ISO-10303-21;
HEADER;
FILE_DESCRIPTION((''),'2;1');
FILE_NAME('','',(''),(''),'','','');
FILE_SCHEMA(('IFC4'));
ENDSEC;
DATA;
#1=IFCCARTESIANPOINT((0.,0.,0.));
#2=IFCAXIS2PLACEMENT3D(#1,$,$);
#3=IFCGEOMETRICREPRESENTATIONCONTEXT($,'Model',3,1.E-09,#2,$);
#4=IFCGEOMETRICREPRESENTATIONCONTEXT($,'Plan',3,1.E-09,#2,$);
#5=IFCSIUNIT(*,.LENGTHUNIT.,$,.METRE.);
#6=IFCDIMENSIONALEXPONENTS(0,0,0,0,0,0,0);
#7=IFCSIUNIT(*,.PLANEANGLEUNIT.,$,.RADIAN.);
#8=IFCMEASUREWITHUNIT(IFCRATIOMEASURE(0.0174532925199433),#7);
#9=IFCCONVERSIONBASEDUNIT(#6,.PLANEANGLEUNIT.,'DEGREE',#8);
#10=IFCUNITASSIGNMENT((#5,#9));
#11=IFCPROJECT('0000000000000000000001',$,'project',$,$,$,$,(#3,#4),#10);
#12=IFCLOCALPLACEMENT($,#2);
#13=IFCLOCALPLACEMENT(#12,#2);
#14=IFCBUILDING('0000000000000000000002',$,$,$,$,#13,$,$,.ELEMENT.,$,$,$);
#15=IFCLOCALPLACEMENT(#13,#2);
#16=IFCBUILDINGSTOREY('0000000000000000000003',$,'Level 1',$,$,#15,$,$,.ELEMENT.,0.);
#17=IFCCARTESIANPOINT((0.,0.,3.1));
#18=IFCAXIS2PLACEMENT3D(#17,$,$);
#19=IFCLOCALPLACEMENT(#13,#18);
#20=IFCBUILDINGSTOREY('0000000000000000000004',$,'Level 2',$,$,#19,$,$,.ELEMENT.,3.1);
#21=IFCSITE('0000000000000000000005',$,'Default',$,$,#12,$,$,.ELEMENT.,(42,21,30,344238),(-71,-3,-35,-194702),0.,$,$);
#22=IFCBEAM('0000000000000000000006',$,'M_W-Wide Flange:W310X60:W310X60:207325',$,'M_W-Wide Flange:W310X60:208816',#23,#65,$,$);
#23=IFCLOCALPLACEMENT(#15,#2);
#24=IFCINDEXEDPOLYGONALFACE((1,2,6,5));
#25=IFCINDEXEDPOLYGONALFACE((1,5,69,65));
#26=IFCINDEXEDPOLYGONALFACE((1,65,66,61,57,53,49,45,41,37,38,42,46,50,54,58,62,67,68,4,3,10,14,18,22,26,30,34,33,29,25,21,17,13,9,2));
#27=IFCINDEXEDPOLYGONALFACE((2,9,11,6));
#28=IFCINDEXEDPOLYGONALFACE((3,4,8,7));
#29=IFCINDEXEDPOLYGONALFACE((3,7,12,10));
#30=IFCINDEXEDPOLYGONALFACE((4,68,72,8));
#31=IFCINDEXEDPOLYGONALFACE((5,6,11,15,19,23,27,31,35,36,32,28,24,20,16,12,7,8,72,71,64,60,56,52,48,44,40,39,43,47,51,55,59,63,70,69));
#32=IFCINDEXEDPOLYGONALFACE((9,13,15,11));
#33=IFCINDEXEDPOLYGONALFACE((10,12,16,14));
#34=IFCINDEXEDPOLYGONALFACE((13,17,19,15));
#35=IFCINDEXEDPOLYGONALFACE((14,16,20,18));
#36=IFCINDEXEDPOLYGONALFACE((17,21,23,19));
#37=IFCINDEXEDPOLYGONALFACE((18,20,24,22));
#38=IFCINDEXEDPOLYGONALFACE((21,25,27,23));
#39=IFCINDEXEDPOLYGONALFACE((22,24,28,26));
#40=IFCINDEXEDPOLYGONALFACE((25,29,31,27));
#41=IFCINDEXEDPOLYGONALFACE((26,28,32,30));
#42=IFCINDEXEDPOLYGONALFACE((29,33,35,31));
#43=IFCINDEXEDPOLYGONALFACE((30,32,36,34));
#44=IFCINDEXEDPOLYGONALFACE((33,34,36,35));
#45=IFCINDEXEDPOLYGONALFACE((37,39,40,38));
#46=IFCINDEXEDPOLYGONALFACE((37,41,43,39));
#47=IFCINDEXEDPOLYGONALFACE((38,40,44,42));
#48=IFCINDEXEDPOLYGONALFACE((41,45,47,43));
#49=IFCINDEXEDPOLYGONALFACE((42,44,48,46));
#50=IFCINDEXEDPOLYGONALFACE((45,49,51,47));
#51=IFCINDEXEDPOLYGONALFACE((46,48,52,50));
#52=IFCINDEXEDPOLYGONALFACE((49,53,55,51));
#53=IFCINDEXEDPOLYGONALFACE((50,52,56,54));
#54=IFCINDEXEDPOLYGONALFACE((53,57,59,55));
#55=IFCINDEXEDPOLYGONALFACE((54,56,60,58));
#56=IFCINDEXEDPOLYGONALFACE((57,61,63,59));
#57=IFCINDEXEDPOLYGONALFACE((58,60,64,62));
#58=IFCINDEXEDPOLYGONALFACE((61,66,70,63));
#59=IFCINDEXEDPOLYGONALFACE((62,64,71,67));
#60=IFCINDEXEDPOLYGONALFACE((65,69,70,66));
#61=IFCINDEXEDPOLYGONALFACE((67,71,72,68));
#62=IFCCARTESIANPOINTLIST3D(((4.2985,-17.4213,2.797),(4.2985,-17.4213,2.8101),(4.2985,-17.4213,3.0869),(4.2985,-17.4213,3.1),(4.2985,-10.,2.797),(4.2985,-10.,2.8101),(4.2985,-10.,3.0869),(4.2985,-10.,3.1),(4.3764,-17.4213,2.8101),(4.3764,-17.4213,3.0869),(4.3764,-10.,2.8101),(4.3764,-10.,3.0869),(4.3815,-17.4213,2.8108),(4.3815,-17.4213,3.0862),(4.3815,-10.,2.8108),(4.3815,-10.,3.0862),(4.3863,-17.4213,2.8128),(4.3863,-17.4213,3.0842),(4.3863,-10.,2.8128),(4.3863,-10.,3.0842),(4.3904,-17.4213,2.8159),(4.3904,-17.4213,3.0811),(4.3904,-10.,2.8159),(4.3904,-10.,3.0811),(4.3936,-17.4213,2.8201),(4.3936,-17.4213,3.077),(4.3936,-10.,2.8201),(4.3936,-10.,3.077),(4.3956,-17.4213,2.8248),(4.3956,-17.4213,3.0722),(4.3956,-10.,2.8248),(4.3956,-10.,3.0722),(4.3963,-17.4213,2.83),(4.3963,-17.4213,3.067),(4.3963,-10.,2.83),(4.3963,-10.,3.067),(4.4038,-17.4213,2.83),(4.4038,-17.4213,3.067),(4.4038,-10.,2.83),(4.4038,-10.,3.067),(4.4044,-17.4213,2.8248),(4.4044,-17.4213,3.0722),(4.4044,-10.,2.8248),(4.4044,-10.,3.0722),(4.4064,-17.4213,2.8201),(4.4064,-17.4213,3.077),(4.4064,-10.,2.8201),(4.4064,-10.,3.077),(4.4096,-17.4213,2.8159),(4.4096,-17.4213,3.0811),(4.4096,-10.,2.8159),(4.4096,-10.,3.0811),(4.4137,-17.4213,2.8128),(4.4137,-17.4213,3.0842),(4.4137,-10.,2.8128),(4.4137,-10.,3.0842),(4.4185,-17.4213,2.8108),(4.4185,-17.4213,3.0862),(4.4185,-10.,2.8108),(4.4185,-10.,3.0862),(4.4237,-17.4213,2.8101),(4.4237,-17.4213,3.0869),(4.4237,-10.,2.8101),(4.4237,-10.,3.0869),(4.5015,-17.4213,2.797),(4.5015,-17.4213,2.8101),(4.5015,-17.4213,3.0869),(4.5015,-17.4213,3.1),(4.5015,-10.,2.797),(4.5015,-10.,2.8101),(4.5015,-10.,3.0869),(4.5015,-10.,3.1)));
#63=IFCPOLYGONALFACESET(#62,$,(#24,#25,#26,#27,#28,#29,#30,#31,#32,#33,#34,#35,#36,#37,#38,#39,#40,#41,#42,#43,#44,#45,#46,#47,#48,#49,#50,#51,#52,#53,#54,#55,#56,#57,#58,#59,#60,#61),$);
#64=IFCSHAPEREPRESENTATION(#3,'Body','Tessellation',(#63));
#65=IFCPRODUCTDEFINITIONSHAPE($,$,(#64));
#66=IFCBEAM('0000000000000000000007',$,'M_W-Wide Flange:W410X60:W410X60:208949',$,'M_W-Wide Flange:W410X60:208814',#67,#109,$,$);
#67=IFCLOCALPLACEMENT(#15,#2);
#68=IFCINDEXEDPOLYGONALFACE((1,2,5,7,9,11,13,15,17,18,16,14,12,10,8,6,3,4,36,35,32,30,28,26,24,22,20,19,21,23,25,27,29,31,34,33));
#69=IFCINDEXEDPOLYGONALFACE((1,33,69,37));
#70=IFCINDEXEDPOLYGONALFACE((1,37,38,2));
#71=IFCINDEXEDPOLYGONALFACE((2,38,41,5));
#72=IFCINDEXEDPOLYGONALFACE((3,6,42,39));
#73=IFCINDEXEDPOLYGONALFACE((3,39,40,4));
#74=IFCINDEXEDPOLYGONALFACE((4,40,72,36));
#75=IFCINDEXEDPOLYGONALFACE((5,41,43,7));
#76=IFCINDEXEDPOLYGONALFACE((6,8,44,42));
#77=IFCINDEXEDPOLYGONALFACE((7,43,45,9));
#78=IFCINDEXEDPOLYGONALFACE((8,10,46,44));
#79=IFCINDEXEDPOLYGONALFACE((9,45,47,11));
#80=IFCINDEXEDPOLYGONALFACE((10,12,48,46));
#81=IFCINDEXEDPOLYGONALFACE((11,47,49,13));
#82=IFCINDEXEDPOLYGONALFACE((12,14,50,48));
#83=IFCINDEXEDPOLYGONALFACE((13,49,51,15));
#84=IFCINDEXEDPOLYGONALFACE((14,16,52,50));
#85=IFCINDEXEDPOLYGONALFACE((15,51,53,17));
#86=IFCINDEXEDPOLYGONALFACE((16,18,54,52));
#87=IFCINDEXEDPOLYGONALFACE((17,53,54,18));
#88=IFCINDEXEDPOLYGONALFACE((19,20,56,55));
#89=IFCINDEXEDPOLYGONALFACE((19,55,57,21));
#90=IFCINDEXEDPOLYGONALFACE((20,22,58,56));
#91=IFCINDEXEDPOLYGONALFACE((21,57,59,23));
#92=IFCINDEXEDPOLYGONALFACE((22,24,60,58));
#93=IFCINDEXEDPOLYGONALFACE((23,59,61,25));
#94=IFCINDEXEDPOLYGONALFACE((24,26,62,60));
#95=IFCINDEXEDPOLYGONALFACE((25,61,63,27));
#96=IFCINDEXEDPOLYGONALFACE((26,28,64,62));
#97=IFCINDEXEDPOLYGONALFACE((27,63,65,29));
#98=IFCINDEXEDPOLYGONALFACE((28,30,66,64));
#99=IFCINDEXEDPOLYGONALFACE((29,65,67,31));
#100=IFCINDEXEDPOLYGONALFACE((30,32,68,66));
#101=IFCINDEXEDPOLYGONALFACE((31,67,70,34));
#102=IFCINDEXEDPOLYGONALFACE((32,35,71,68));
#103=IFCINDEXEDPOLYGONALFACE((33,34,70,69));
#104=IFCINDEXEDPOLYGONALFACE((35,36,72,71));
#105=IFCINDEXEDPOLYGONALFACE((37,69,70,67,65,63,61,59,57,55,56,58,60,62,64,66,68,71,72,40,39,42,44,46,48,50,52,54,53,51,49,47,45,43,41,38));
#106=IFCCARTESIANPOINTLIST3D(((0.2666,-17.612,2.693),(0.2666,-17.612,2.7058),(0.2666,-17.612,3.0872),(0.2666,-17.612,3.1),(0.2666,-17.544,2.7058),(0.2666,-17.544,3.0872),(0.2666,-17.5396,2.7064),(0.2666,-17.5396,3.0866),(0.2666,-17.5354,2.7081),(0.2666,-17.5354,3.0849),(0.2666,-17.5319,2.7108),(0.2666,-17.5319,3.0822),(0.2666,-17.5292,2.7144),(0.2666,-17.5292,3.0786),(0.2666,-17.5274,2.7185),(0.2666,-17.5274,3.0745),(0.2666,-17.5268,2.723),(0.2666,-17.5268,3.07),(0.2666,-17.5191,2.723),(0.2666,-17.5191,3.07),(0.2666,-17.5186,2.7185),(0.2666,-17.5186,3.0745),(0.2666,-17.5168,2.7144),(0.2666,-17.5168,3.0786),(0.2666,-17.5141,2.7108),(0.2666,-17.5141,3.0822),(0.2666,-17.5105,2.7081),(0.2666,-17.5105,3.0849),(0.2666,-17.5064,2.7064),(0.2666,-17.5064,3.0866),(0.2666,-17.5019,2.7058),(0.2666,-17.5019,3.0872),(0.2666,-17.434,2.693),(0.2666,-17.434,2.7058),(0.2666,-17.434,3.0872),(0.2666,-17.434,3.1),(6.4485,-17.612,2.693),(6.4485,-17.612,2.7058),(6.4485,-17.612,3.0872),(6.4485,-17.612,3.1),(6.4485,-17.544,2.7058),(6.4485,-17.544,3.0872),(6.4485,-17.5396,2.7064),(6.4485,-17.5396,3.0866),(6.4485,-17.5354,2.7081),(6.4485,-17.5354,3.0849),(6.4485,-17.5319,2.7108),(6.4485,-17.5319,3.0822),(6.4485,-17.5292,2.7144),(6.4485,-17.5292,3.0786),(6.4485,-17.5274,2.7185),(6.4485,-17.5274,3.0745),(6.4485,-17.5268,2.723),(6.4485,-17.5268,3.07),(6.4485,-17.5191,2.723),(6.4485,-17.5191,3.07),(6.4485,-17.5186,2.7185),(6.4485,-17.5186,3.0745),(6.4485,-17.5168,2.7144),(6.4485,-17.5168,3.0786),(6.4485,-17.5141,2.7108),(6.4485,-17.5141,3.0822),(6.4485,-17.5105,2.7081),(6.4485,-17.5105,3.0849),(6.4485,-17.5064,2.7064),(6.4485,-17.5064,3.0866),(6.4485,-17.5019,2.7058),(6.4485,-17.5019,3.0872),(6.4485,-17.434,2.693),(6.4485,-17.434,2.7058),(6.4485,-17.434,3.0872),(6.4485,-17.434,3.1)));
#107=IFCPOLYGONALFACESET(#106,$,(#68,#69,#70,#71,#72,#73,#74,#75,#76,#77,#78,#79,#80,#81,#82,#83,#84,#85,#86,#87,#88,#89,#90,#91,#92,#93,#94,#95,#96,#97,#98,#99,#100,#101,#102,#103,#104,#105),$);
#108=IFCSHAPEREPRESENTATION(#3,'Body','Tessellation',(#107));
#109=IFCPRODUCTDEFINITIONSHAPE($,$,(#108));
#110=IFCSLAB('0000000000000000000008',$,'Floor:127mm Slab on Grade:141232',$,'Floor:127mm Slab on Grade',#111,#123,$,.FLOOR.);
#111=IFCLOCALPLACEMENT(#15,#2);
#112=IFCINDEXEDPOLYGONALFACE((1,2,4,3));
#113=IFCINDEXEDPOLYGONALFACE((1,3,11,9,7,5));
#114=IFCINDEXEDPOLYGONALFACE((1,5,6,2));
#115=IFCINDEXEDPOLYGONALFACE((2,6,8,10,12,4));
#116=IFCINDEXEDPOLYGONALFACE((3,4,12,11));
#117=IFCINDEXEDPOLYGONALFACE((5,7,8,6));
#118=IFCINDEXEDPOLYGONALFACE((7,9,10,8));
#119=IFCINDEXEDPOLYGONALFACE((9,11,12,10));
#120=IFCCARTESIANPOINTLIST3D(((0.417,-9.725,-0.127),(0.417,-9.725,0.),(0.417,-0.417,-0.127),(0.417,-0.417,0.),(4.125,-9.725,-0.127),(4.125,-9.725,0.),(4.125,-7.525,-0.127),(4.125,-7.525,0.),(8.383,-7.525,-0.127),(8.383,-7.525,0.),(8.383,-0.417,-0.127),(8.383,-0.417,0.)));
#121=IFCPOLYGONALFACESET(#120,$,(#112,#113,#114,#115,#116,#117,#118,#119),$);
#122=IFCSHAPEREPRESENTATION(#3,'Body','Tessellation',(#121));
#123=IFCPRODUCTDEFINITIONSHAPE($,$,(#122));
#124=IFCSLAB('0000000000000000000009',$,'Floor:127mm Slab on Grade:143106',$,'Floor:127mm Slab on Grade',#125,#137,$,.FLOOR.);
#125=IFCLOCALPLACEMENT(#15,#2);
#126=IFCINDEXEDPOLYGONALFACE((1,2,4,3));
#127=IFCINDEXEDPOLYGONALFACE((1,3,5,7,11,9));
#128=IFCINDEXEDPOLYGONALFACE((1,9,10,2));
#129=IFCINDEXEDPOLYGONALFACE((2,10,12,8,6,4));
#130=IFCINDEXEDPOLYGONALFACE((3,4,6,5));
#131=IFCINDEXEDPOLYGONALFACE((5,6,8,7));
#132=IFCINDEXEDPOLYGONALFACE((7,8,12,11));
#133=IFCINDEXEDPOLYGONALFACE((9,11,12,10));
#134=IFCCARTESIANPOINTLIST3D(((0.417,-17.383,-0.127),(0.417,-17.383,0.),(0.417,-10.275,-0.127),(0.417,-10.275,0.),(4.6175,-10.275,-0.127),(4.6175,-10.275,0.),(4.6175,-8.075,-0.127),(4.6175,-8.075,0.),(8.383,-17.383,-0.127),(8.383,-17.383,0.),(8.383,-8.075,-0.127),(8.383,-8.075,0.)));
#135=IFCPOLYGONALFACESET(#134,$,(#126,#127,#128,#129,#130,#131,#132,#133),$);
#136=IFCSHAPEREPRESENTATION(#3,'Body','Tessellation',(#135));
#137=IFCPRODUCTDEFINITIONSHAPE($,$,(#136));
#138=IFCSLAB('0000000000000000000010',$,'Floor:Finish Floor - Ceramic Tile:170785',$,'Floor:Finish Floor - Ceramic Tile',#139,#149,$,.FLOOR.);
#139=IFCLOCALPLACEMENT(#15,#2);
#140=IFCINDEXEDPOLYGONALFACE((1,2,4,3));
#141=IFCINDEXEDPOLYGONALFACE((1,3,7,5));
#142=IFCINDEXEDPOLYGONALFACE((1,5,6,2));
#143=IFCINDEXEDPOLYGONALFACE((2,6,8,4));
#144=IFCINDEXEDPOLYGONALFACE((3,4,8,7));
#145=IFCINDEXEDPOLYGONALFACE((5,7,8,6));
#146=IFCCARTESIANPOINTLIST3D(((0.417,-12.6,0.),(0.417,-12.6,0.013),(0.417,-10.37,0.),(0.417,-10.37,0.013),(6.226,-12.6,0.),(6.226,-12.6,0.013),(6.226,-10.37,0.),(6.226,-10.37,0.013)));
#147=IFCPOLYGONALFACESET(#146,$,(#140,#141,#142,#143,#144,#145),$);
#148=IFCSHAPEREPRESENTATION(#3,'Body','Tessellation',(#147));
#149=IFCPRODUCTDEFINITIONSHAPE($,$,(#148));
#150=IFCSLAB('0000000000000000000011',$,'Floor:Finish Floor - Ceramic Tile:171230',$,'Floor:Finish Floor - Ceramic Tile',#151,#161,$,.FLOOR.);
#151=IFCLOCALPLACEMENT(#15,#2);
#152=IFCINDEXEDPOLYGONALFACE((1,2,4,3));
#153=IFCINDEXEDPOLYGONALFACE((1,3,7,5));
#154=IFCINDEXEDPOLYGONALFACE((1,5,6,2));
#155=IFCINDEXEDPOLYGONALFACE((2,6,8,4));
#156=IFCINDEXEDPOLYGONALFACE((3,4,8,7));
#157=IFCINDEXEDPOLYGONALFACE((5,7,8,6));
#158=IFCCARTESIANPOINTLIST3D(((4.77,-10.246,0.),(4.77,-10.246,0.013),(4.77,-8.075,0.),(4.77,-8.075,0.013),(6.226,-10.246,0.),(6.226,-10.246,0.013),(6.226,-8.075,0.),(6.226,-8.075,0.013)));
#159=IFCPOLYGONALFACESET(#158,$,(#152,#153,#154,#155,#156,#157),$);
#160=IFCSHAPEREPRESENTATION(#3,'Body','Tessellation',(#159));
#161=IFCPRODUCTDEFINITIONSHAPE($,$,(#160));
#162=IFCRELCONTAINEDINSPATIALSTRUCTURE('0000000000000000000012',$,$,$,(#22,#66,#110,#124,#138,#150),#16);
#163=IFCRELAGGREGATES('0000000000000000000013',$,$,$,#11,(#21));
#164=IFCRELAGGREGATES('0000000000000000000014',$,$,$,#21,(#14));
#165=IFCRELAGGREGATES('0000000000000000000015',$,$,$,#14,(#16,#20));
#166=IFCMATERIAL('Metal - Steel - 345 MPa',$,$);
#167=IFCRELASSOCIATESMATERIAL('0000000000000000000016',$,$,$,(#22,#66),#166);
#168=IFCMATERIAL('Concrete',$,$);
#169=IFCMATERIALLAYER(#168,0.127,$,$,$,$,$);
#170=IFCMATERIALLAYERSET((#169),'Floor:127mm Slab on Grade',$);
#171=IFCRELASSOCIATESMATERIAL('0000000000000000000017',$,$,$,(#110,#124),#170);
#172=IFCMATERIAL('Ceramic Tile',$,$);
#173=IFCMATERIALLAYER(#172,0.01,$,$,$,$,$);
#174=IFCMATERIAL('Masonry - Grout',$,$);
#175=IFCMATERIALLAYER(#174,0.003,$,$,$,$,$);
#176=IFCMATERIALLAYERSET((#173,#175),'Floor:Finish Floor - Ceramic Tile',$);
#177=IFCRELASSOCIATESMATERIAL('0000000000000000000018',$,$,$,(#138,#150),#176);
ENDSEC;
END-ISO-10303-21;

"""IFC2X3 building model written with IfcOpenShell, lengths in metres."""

from ifc_helpers import new_model, entity, si_unit, converted_unit, frame, frame_2d, origin, place, context, project, spatial, polyline, circle_curve, parameter, trimmed, segment, composite_curve, rectangle, outline, extrude, material, layer, layer_set, layer_usage, element, save


model = new_model("IFC2X3")

# Units and contexts
model_context = context("Model", 3, precision=1e-09, world=origin())
plan_context = context("Plan", 3, precision=1e-09, world=origin())
ifc_project = project(units=[si_unit("LENGTHUNIT", "METRE"), converted_unit("PLANEANGLEUNIT", "DEGREE", entity("IfcRatioMeasure", 0.0174532925199433), si_unit("PLANEANGLEUNIT", "RADIAN"), dimensions=[0, 0, 0, 0, 0, 0, 0])], contexts=[model_context, plan_context])

# Site, building, storey
site_placement = place(None, origin())
site = spatial("IfcSite", under=ifc_project, at=site_placement, Name="Default", CompositionType="ELEMENT", RefLatitude=(42, 21, 30, 344238), RefLongitude=(-71, -3, -35, -194702), RefElevation=0.0)
building_placement = place(site_placement, origin())
building = spatial("IfcBuilding", under=site, at=building_placement, CompositionType="ELEMENT")
storey_1_placement = place(building_placement, origin())
storey_1 = spatial("IfcBuildingStorey", under=building, at=storey_1_placement, Name="Level 1", CompositionType="ELEMENT", Elevation=0.0)

# Beams
ifc_material_1 = material(Name="Metal - Steel - 345 MPa")
beam_1_placement = place(storey_1_placement, frame((4.4, -10.0, 3.1), z_axis=(0.0, 0.0, 1.0), x_axis=(-1.0, 0.0, 0.0)))
element("IfcBeam", 1, at=beam_1_placement, inside=storey_1, material=ifc_material_1, Name="M_W-Wide Flange:W310X60:W310X60:207325", ObjectType="M_W-Wide Flange:W310X60:208816", context=model_context, shape_type="SweptSolid", body=[
    extrude(outline(composite_curve([segment(polyline([(0.1384, -0.1015), (0.1515, -0.1015)]), True, "CONTINUOUS"), segment(polyline([(0.1515, -0.1015), (0.1515, 0.1015)]), True, "CONTINUOUS"), segment(polyline([(0.1515, 0.1015), (0.1384, 0.1015)]), True, "CONTINUOUS"), segment(polyline([(0.1384, 0.1015), (0.1384, 0.0236)]), True, "CONTINUOUS"), segment(trimmed(circle_curve(frame_2d((0.1185, 0.0236), x_axis=(0.0, 1.0)), 0.0199), [parameter(180.0)], [parameter(270.0)], True, "PARAMETER"), False, "CONTINUOUS"), segment(polyline([(0.1185, 0.0037), (-0.1185, 0.0037)]), True, "CONTINUOUS"), segment(trimmed(circle_curve(frame_2d((-0.1185, 0.0236), x_axis=(0.0, 1.0)), 0.0199), [parameter(90.0)], [parameter(180.0)], True, "PARAMETER"), False, "CONTINUOUS"), segment(polyline([(-0.1384, 0.0236), (-0.1384, 0.1015)]), True, "CONTINUOUS"), segment(polyline([(-0.1384, 0.1015), (-0.1515, 0.1015)]), True, "CONTINUOUS"), segment(polyline([(-0.1515, 0.1015), (-0.1515, -0.1015)]), True, "CONTINUOUS"), segment(polyline([(-0.1515, -0.1015), (-0.1384, -0.1015)]), True, "CONTINUOUS"), segment(polyline([(-0.1384, -0.1015), (-0.1384, -0.0237)]), True, "CONTINUOUS"), segment(trimmed(circle_curve(frame_2d((-0.1185, -0.0237), x_axis=(0.0, 1.0)), 0.0199), [parameter(360.0)], [parameter(90.0)], True, "PARAMETER"), False, "CONTINUOUS"), segment(polyline([(-0.1185, -0.0038), (0.1185, -0.0038)]), True, "CONTINUOUS"), segment(trimmed(circle_curve(frame_2d((0.1185, -0.0237), x_axis=(0.0, 1.0)), 0.0199), [parameter(270.0)], [parameter(0.0)], True, "PARAMETER"), False, "CONTINUOUS"), segment(polyline([(0.1384, -0.0237), (0.1384, -0.1015)]), True, "CONTINUOUS")], self_intersect=False)), frame((0.0, 7.4213, -0.1515), z_axis=(0.0, -1.0, 0.0), x_axis=(0.0, 0.0, -1.0)), (0.0, 0.0, 1.0), 7.4213),
])
beam_2_placement = place(storey_1_placement, frame((0.2085, -17.523, 3.1), z_axis=(0.0, 0.0, 1.0), x_axis=(0.0, -1.0, 0.0)))
element("IfcBeam", 2, at=beam_2_placement, inside=storey_1, material=ifc_material_1, Name="M_W-Wide Flange:W410X60:W410X60:208949", ObjectType="M_W-Wide Flange:W410X60:208814", context=model_context, shape_type="SweptSolid", body=[
    extrude(outline(composite_curve([segment(polyline([(-0.089, -0.1907), (-0.089, -0.2035)]), True, "CONTINUOUS"), segment(polyline([(-0.089, -0.2035), (0.089, -0.2035)]), True, "CONTINUOUS"), segment(polyline([(0.089, -0.2035), (0.089, -0.1907)]), True, "CONTINUOUS"), segment(polyline([(0.089, -0.1907), (0.021, -0.1907)]), True, "CONTINUOUS"), segment(trimmed(circle_curve(frame_2d((0.021, -0.1735), x_axis=(0.0, -1.0)), 0.0172), [parameter(270.0)], [parameter(360.0)], True, "PARAMETER"), False, "CONTINUOUS"), segment(polyline([(0.0038, -0.1735), (0.0038, 0.1735)]), True, "CONTINUOUS"), segment(trimmed(circle_curve(frame_2d((0.021, 0.1735), x_axis=(-1.0, 0.0)), 0.0172), [parameter(270.0)], [parameter(360.0)], True, "PARAMETER"), False, "CONTINUOUS"), segment(polyline([(0.021, 0.1907), (0.089, 0.1907)]), True, "CONTINUOUS"), segment(polyline([(0.089, 0.1907), (0.089, 0.2035)]), True, "CONTINUOUS"), segment(polyline([(0.089, 0.2035), (-0.089, 0.2035)]), True, "CONTINUOUS"), segment(polyline([(-0.089, 0.2035), (-0.089, 0.1907)]), True, "CONTINUOUS"), segment(polyline([(-0.089, 0.1907), (-0.0211, 0.1907)]), True, "CONTINUOUS"), segment(trimmed(circle_curve(frame_2d((-0.0211, 0.1735), x_axis=(0.0, 1.0)), 0.0172), [parameter(270.0)], [parameter(0.0)], True, "PARAMETER"), False, "CONTINUOUS"), segment(polyline([(-0.0039, 0.1735), (-0.0039, -0.1735)]), True, "CONTINUOUS"), segment(trimmed(circle_curve(frame_2d((-0.0211, -0.1735), x_axis=(1.0, 0.0)), 0.0172), [parameter(270.0)], [parameter(0.0)], True, "PARAMETER"), False, "CONTINUOUS"), segment(polyline([(-0.0211, -0.1907), (-0.089, -0.1907)]), True, "CONTINUOUS")], self_intersect=False)), frame((0.0, 0.0581, -0.2035), z_axis=(0.0, -1.0, 0.0), x_axis=(1.0, 0.0, 0.0)), (0.0, 0.0, -1.0), 6.1819),
])

# Slabs
ifc_material_2 = material(Name="Concrete")
ifc_layer_1 = layer(ifc_material_2, 0.127)
ifc_layer_set_1 = layer_set([ifc_layer_1], Name="Floor:127mm Slab on Grade")
ifc_layer_usage_1 = layer_usage(ifc_layer_set_1, "AXIS3", "POSITIVE", 0.0)
slab_1_placement = place(storey_1_placement, frame((0.417, -9.725, -0.127)))
element("IfcSlab", 3, at=slab_1_placement, inside=storey_1, material=ifc_layer_usage_1, Name="Floor:127mm Slab on Grade:141232", ObjectType="Floor:127mm Slab on Grade", PredefinedType="FLOOR", context=model_context, shape_type="SweptSolid", body=[
    extrude(outline(polyline([(-3.983, 4.654), (-3.983, -2.454), (0.275, -2.454), (0.275, -4.654), (3.983, -4.654), (3.983, 4.654), (-3.983, 4.654)])), frame((3.983, 4.654, 0.127), z_axis=(0.0, 0.0, -1.0), x_axis=(-1.0, 0.0, 0.0)), (0.0, 0.0, 1.0), 0.127),
])
slab_2_placement = place(storey_1_placement, frame((0.417, -17.383, -0.127)))
element("IfcSlab", 4, at=slab_2_placement, inside=storey_1, material=ifc_layer_usage_1, Name="Floor:127mm Slab on Grade:143106", ObjectType="Floor:127mm Slab on Grade", PredefinedType="FLOOR", context=model_context, shape_type="SweptSolid", body=[
    extrude(outline(polyline([(-3.983, 4.654), (-3.983, -4.654), (3.983, -4.654), (3.983, 2.454), (-0.2175, 2.454), (-0.2175, 4.654), (-3.983, 4.654)])), frame((3.983, 4.654, 0.127), z_axis=(0.0, 0.0, -1.0), x_axis=(-1.0, 0.0, 0.0)), (0.0, 0.0, 1.0), 0.127),
])
ifc_material_3 = material(Name="Ceramic Tile")
ifc_layer_2 = layer(ifc_material_3, 0.01)
ifc_material_4 = material(Name="Masonry - Grout")
ifc_layer_3 = layer(ifc_material_4, 0.003)
ifc_layer_set_2 = layer_set([ifc_layer_2, ifc_layer_3], Name="Floor:Finish Floor - Ceramic Tile")
ifc_layer_usage_2 = layer_usage(ifc_layer_set_2, "AXIS3", "POSITIVE", 0.0)
slab_3_placement = place(storey_1_placement, frame((0.417, -12.6, 0.0)))
element("IfcSlab", 5, at=slab_3_placement, inside=storey_1, material=ifc_layer_usage_2, Name="Floor:Finish Floor - Ceramic Tile:170785", ObjectType="Floor:Finish Floor - Ceramic Tile", PredefinedType="FLOOR", context=model_context, shape_type="SweptSolid", body=[
    extrude(rectangle(XDim=5.809, YDim=2.23, at=frame_2d((0.0, 0.0), x_axis=(-1.0, 0.0))), frame((2.9045, 1.115, 0.013), z_axis=(0.0, 0.0, -1.0), x_axis=(-1.0, 0.0, 0.0)), (0.0, 0.0, 1.0), 0.013),
])
slab_4_placement = place(storey_1_placement, frame((4.77, -10.246, 0.0)))
element("IfcSlab", 6, at=slab_4_placement, inside=storey_1, material=ifc_layer_usage_2, Name="Floor:Finish Floor - Ceramic Tile:171230", ObjectType="Floor:Finish Floor - Ceramic Tile", PredefinedType="FLOOR", context=model_context, shape_type="SweptSolid", body=[
    extrude(rectangle(XDim=1.456, YDim=2.171, at=frame_2d((0.0, 0.0), x_axis=(-1.0, 0.0))), frame((0.728, 1.0855, 0.013), z_axis=(0.0, 0.0, -1.0), x_axis=(-1.0, 0.0, 0.0)), (0.0, 0.0, 1.0), 0.013),
])

# Shared definitions
storey_2_placement = place(building_placement, frame((0.0, 0.0, 3.1)))
storey_2 = spatial("IfcBuildingStorey", under=building, at=storey_2_placement, Name="Level 2", CompositionType="ELEMENT", Elevation=3.1)

save(model, "model.ifc")
